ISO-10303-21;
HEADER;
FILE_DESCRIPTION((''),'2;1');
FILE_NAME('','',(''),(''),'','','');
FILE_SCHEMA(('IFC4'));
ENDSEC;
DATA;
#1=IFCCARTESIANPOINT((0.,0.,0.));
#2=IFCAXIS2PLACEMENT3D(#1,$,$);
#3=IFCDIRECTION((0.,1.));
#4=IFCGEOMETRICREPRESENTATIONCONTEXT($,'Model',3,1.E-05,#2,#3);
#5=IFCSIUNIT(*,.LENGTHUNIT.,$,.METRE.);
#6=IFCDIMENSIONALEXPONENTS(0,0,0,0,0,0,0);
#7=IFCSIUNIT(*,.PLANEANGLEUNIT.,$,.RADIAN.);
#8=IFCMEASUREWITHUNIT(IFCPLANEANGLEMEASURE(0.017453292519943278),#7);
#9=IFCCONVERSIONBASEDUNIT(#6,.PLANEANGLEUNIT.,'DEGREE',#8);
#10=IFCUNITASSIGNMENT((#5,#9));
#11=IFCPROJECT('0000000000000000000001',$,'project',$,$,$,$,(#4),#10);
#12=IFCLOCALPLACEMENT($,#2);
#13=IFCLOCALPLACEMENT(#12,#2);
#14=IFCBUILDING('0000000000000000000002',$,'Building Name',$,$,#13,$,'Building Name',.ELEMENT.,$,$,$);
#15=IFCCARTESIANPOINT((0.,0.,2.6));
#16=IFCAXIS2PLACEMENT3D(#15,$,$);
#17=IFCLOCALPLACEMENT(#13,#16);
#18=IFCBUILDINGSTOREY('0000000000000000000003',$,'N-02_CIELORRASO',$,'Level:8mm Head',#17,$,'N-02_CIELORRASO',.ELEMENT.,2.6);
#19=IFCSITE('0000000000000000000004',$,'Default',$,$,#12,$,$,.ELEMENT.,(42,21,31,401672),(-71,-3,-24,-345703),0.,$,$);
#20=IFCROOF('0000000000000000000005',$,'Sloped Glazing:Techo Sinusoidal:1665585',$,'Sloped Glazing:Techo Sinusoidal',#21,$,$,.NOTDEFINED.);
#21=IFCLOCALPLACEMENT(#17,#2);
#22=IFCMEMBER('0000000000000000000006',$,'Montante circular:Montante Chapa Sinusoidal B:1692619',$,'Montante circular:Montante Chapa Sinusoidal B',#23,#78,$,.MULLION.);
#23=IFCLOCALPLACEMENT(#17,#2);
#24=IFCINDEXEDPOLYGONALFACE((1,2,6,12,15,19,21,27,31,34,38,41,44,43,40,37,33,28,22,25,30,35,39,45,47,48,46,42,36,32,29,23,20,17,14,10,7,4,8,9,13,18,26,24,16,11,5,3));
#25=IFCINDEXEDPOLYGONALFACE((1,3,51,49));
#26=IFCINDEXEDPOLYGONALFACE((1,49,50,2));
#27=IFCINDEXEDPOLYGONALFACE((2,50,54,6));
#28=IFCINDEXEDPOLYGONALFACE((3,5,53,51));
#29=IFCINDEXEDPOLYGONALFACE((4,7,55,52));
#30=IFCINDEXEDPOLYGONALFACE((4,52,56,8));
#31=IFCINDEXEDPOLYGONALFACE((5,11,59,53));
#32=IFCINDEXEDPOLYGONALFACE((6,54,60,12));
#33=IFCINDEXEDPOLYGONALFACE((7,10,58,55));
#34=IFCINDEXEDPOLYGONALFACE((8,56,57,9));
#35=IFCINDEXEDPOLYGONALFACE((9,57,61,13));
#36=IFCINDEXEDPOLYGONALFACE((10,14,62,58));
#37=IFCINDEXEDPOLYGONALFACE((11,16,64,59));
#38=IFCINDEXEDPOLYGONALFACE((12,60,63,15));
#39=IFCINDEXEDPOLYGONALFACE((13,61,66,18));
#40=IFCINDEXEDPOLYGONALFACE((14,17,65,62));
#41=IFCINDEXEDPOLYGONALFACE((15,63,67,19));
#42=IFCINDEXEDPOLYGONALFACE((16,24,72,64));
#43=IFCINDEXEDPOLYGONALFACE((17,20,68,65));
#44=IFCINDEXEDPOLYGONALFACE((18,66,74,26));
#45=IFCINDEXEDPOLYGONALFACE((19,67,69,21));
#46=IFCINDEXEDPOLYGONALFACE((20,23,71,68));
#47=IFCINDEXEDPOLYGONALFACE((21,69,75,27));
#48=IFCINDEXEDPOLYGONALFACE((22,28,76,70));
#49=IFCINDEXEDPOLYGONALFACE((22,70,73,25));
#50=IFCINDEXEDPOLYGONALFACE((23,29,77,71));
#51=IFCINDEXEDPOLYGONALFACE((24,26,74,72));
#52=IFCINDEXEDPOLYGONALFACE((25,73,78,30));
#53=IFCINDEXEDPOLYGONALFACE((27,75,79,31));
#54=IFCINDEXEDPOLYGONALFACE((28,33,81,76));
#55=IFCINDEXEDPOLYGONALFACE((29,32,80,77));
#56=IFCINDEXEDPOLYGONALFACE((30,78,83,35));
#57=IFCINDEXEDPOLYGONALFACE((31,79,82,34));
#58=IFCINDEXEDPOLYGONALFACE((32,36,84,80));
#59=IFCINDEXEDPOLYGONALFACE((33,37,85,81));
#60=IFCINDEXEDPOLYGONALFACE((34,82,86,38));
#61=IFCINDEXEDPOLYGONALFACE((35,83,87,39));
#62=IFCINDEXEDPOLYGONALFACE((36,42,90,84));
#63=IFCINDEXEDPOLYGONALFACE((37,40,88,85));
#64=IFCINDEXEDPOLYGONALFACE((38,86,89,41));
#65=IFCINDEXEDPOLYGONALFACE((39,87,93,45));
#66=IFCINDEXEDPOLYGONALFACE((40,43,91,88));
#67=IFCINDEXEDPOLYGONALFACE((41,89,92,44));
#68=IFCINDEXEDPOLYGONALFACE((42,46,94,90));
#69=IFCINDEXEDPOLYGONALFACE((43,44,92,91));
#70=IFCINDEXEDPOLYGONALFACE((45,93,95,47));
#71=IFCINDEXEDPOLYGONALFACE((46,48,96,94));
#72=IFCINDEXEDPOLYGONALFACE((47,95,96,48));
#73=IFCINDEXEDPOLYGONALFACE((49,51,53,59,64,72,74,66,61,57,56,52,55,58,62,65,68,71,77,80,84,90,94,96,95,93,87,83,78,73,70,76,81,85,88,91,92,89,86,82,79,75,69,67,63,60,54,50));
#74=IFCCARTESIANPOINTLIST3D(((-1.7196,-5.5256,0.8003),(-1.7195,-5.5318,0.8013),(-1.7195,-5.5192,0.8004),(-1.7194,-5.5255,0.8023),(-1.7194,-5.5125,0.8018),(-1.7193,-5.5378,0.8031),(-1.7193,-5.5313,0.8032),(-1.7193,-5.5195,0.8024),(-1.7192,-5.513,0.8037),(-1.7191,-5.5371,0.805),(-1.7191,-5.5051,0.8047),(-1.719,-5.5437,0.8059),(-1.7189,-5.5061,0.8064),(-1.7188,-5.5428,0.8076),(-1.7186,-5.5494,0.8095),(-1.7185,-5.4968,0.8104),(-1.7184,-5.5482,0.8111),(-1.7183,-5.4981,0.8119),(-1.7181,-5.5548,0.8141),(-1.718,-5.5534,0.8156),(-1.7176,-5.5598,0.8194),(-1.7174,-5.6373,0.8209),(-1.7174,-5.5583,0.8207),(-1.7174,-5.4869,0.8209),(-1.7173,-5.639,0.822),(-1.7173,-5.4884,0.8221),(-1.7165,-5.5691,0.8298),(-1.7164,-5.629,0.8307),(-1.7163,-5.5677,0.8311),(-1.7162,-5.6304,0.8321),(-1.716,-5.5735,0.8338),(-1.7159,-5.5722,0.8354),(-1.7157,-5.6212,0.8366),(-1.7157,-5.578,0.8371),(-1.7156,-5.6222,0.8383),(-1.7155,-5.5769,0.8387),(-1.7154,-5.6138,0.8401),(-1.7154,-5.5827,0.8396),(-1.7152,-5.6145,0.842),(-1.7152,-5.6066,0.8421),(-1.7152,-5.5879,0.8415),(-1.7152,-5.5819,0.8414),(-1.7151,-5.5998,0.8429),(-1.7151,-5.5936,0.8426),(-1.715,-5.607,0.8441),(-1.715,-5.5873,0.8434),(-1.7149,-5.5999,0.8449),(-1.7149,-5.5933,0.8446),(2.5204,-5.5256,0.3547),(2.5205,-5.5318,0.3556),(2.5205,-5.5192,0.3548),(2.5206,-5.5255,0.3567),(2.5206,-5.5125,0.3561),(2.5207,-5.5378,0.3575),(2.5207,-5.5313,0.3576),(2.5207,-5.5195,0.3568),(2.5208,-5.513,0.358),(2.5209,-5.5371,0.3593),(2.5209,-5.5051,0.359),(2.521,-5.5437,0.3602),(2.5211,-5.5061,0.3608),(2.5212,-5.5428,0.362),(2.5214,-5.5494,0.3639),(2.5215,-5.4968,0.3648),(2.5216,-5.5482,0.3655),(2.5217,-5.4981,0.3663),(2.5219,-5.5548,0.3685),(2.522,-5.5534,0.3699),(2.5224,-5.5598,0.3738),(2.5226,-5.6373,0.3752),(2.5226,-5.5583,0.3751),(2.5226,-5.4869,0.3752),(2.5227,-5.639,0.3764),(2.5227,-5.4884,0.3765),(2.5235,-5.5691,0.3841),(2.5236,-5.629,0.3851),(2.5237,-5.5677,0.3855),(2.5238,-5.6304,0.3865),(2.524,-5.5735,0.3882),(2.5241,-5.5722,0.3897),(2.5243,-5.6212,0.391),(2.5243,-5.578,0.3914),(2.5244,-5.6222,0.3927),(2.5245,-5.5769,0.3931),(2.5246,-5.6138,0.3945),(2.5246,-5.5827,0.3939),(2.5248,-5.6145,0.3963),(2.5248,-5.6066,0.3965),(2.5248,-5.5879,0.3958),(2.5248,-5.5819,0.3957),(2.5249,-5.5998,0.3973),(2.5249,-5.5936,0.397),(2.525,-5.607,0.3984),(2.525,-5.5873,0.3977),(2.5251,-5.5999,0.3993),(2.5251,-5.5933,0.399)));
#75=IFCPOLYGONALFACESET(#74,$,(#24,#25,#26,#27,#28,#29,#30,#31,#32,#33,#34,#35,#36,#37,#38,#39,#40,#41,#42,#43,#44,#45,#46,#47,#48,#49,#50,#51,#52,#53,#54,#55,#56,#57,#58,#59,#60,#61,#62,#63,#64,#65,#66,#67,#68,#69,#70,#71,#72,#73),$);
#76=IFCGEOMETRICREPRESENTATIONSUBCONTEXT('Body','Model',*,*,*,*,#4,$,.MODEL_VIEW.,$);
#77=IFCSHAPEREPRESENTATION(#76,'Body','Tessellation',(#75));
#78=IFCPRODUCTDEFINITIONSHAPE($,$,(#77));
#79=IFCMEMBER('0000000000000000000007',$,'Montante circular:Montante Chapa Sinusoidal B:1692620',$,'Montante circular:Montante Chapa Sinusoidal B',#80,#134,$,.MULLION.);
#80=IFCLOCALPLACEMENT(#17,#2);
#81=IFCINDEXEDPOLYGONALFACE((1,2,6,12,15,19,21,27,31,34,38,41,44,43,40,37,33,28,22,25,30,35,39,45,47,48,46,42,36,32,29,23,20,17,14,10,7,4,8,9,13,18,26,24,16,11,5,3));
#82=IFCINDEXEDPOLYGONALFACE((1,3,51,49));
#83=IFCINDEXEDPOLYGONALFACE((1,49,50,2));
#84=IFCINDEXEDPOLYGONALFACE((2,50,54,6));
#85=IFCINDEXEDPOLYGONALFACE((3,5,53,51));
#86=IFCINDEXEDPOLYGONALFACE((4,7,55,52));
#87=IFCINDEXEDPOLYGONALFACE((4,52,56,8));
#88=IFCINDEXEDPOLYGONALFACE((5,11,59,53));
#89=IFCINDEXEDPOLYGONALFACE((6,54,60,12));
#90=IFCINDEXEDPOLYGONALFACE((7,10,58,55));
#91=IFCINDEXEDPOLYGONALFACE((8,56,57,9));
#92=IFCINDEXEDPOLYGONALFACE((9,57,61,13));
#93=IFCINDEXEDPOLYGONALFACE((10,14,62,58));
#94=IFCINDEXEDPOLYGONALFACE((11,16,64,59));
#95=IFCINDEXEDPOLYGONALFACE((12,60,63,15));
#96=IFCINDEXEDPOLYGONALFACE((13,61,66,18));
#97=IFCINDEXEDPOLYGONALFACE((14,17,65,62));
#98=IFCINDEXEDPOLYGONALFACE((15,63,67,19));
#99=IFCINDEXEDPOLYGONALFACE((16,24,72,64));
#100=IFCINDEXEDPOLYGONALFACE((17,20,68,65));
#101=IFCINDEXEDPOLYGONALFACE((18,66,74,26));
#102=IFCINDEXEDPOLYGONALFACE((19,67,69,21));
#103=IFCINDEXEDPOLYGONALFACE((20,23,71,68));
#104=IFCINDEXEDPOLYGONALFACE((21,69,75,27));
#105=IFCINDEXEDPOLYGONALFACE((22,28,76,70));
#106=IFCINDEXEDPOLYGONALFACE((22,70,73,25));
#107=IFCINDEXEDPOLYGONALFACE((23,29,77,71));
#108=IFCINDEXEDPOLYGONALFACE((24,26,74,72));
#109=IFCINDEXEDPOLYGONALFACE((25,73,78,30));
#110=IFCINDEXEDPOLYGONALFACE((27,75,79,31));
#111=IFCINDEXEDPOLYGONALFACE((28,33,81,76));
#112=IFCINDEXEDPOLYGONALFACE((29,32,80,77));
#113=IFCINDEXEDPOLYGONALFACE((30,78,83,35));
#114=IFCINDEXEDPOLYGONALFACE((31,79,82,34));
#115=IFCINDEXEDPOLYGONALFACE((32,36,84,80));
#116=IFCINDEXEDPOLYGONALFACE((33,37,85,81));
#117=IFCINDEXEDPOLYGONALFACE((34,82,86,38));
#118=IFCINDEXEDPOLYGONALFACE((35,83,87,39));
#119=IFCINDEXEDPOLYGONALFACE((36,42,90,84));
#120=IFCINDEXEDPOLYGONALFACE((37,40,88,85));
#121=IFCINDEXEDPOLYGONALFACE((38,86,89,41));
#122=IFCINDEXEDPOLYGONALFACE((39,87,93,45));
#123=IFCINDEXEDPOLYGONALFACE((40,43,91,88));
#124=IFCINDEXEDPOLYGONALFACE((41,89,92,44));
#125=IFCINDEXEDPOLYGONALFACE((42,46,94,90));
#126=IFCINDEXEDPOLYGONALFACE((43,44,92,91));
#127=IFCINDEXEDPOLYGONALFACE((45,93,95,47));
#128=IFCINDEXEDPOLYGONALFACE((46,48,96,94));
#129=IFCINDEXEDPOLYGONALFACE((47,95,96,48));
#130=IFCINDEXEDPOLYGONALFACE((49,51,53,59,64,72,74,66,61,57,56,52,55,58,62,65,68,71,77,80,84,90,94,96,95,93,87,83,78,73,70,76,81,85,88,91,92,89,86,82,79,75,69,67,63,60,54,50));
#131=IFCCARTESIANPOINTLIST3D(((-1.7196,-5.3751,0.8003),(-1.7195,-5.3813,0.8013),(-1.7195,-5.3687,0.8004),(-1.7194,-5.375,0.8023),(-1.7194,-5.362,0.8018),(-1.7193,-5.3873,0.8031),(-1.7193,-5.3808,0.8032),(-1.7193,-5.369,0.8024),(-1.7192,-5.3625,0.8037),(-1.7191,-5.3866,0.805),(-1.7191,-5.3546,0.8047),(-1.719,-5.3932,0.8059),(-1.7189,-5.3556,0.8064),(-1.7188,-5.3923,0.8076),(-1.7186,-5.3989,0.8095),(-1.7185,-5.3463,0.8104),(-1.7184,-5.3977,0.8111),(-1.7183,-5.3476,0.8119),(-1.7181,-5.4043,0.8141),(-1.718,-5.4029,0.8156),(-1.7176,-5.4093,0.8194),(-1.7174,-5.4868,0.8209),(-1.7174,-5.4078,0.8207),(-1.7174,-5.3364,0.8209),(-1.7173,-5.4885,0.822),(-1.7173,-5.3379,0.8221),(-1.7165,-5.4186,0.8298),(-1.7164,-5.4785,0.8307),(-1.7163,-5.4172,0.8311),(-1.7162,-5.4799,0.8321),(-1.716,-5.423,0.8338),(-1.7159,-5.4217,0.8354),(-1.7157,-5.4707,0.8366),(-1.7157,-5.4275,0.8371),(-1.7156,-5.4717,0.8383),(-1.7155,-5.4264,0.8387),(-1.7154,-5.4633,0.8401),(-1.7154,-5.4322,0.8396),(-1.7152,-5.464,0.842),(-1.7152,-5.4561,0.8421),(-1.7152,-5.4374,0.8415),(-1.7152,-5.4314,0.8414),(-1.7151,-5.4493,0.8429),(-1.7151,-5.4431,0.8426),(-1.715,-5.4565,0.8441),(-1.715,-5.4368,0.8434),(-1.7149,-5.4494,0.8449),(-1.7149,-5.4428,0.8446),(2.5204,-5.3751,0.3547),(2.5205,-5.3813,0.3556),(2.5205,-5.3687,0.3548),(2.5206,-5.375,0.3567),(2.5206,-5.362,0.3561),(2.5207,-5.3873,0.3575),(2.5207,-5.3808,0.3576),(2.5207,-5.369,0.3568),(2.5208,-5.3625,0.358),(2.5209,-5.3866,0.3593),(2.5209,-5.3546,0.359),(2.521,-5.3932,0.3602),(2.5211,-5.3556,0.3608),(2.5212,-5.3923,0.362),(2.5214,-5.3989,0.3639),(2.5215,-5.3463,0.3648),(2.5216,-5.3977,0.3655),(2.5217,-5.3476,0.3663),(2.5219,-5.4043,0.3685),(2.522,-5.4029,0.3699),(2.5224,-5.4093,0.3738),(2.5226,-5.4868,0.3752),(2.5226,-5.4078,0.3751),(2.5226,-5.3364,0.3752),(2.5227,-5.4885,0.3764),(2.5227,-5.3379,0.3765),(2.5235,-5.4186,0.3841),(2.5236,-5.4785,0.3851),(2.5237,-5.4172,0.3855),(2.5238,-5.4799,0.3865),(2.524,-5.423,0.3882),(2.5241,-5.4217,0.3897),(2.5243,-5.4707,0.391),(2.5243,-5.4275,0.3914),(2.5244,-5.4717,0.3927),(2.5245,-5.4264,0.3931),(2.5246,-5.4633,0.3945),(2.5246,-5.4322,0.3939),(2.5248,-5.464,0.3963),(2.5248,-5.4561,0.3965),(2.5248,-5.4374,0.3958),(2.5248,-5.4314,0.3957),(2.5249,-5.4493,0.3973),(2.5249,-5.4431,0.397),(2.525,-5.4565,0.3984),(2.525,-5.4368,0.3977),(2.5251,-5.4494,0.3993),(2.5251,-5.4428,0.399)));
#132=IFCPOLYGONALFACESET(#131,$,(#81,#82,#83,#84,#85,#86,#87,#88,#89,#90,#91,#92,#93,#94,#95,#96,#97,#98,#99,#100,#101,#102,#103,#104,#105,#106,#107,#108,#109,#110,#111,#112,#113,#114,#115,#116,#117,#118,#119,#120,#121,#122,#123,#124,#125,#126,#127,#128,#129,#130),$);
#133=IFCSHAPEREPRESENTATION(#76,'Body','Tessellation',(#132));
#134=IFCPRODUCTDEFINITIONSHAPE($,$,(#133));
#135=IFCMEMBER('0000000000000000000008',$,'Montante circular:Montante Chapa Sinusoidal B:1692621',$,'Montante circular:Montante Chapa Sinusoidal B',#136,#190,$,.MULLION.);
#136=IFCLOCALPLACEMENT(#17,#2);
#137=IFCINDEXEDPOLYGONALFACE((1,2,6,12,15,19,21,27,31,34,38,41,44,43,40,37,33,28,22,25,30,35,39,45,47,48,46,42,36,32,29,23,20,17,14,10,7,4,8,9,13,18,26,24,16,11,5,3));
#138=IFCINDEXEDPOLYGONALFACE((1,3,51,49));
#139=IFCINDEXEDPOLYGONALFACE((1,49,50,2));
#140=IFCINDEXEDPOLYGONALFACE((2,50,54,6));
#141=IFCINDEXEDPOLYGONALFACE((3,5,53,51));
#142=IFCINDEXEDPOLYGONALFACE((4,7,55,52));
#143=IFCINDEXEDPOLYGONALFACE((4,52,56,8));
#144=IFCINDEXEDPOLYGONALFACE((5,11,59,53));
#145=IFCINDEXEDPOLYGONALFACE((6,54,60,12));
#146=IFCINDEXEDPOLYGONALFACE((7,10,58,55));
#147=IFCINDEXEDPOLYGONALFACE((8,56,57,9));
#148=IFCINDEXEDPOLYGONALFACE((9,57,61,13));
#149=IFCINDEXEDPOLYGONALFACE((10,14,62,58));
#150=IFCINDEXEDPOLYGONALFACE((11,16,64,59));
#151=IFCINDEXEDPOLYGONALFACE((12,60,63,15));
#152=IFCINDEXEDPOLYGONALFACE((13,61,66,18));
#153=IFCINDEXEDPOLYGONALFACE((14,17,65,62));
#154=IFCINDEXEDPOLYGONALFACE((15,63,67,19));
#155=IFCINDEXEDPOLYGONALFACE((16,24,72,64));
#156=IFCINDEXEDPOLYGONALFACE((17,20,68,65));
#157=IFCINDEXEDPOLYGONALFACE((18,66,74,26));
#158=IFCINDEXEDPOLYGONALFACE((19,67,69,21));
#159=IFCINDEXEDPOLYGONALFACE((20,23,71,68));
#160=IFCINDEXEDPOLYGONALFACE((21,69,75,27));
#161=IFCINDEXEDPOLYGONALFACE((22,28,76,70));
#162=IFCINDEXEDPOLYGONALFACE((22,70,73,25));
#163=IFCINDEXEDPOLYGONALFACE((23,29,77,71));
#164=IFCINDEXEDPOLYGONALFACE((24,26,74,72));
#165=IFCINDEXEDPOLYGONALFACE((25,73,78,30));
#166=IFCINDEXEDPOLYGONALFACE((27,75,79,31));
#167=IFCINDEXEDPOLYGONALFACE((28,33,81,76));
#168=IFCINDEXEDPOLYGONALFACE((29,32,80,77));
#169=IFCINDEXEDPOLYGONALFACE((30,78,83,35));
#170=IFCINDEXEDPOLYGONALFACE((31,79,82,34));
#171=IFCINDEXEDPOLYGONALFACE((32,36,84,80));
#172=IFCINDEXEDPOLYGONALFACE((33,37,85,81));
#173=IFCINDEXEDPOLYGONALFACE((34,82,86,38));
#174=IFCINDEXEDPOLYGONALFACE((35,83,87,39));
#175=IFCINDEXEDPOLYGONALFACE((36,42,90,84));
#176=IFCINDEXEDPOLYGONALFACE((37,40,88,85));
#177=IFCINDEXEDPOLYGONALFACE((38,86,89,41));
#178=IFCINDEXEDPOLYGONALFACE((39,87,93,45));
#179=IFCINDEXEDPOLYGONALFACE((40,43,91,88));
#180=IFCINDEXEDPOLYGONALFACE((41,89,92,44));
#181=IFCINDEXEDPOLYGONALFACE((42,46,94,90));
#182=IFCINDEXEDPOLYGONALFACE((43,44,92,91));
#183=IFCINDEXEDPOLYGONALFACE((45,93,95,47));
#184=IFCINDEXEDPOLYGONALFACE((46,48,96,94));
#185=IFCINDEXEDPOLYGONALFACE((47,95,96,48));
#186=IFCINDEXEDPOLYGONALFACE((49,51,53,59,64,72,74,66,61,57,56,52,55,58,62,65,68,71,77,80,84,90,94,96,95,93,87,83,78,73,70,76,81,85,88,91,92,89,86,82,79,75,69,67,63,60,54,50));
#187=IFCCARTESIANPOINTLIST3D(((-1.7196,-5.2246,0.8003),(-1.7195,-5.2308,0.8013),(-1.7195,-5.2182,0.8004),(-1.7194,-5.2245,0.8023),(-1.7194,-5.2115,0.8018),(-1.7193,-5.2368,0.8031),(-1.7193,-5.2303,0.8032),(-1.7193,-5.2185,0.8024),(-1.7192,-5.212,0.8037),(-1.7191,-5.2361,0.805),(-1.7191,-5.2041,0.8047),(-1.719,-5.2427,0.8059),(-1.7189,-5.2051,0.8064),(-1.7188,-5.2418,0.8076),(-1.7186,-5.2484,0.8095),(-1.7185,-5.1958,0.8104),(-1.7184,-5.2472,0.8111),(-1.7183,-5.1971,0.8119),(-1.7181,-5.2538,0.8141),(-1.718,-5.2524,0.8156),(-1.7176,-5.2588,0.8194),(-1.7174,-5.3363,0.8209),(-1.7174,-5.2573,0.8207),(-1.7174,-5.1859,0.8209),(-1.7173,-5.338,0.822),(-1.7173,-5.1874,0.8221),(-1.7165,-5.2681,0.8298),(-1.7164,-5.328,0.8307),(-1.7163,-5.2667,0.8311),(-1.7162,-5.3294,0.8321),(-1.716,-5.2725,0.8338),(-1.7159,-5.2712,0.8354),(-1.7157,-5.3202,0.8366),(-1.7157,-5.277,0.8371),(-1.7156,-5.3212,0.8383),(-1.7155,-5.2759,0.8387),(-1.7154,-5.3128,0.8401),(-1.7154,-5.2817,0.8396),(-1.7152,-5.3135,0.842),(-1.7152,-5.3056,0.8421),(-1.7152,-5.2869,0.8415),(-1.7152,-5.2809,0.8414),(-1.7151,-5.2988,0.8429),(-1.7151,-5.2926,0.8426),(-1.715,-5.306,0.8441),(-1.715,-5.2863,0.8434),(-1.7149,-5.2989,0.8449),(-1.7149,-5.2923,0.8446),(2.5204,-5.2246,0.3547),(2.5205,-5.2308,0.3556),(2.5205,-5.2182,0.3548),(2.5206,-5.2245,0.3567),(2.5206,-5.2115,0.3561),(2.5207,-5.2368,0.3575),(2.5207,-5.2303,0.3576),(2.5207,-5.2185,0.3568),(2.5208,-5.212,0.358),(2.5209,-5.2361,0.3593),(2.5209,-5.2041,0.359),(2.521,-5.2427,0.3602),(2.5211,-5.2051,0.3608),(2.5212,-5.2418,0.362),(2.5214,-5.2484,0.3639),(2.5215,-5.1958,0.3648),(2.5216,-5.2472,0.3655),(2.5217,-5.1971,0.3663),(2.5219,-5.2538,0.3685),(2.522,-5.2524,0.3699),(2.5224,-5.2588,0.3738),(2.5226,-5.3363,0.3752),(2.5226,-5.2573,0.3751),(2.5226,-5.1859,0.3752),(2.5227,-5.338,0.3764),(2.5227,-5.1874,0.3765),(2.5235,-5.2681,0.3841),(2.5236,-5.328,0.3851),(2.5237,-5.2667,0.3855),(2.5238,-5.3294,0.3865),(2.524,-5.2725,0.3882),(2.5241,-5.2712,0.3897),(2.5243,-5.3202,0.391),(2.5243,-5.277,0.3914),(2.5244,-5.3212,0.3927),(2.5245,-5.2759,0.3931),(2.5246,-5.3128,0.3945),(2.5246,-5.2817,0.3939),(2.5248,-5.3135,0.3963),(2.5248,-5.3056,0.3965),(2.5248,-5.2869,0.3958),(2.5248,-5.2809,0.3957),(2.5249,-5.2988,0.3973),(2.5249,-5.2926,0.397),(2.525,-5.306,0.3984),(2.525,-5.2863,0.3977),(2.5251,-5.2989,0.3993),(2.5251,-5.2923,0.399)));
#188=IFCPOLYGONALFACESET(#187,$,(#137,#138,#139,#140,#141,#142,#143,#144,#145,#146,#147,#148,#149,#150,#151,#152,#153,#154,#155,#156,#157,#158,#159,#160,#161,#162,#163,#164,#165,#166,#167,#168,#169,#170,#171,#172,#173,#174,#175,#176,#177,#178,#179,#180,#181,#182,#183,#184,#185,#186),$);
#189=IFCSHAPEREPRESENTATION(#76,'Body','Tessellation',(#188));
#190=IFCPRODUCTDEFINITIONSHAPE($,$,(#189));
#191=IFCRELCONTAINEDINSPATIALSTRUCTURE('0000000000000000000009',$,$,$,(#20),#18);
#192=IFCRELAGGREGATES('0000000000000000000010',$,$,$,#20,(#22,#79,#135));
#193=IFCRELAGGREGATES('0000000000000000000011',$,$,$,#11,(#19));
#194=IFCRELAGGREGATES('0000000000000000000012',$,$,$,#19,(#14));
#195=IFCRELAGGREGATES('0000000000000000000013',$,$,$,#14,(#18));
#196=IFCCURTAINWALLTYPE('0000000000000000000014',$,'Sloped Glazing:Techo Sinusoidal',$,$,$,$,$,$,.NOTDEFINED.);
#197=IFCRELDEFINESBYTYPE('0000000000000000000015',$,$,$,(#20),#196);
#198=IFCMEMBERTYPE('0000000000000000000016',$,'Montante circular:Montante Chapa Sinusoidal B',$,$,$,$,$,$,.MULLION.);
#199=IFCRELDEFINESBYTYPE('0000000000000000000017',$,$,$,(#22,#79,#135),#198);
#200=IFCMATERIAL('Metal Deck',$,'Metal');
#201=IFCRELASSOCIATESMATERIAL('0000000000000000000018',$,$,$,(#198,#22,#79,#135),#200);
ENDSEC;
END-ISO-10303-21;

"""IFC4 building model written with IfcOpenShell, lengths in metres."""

from ifc_helpers import new_model, entity, si_unit, converted_unit, direction, frame, origin, place, context, subcontext, project, spatial, indexed_curve, outline, extrude, source, transform, mapped, material, type_object, type_shapes, element, aggregate, save


model = new_model("IFC4")

# Units and contexts
model_context = context("Model", 3, precision=1e-05, world=origin(), true_north=direction((0.0, 1.0)))
body_context = subcontext(model_context, "Body", "Model", "MODEL_VIEW")
ifc_project = project(units=[si_unit("LENGTHUNIT", "METRE"), converted_unit("PLANEANGLEUNIT", "DEGREE", entity("IfcPlaneAngleMeasure", 0.017453292519943278), si_unit("PLANEANGLEUNIT", "RADIAN"), dimensions=[0, 0, 0, 0, 0, 0, 0])], contexts=[model_context])

# Site, building, storey
site_placement = place(None, origin())
site = spatial("IfcSite", under=ifc_project, at=site_placement, Name="Default", CompositionType="ELEMENT", RefLatitude=(42, 21, 31, 401672), RefLongitude=(-71, -3, -24, -345703), RefElevation=0.0)
building_placement = place(site_placement, origin())
building = spatial("IfcBuilding", under=site, at=building_placement, Name="Building Name", LongName="Building Name", CompositionType="ELEMENT")
storey_placement = place(building_placement, frame((0.0, 0.0, 2.6)))
storey = spatial("IfcBuildingStorey", under=building, at=storey_placement, Name="N-02_CIELORRASO", ObjectType="Level:8mm Head", LongName="N-02_CIELORRASO", CompositionType="ELEMENT", Elevation=2.6)

# Roof, members
curtain_wall_type = type_object("IfcCurtainWallType", Name="Sloped Glazing:Techo Sinusoidal", PredefinedType="NOTDEFINED")
roof_1_placement = place(storey_placement, frame((0.0, 0.0, -2.6)))
roof_1 = element("IfcRoof", 1, at=roof_1_placement, inside=storey, type_object=curtain_wall_type, Name="Sloped Glazing:Techo Sinusoidal:1665585", ObjectType="Sloped Glazing:Techo Sinusoidal", PredefinedType="NOTDEFINED")
ifc_material = material(Name="Metal Deck", Category="Metal")
member_type_1 = type_object("IfcMemberType", Name="Montante circular:Montante Chapa Sinusoidal B", PredefinedType="MULLION", material=ifc_material)
shared_shape_1 = source(origin(), body_context, "Body", "SweptSolid", [
    extrude(outline(indexed_curve([(0.0595, -0.0443), (0.0615, -0.0443), (0.0603, -0.031), (0.0572, -0.0213), (0.053, -0.0138), (0.0481, -0.0078), (0.0427, -0.003), (0.0372, 0.0005), (0.0315, 0.0029), (0.0259, 0.0044), (0.0203, 0.0051), (0.0146, 0.005), (0.0084, 0.0041), (-0.0053, 0.0009), (-0.0123, -0.0005), (-0.0191, -0.0012), (-0.0256, -0.001), (-0.0317, 0.0001), (-0.0375, 0.0019), (-0.0428, 0.0046), (-0.0477, 0.0081), (-0.0522, 0.0128), (-0.0563, 0.0191), (-0.0597, 0.0282), (-0.0617, 0.0421), (-0.0637, 0.042), (-0.0616, 0.0277), (-0.0581, 0.0182), (-0.0537, 0.0116), (-0.049, 0.0066), (-0.0438, 0.0028), (-0.0382, 0.0001), (-0.0322, -0.0019), (-0.0258, -0.003), (-0.019, -0.0032), (-0.012, -0.0025), (-0.0048, -0.0011), (0.0088, 0.0021), (0.0147, 0.003), (0.0202, 0.0031), (0.0255, 0.0024), (0.0309, 0.001), (0.0362, -0.0013), (0.0415, -0.0046), (0.0466, -0.0092), (0.0513, -0.0149), (0.0554, -0.0221), (0.0584, -0.0314), (0.0595, -0.0443)], self_intersect=False)), frame((-0.007, 0.0228, -4.2634), z_axis=(0.0, 0.0, 1.0), x_axis=(-0.819152, -0.573576, 0.0)), (0.0, 0.0, 1.0), 4.2634),
])
type_shapes(member_type_1, [shared_shape_1])
member_1_placement = place(roof_1_placement, frame((-1.7148, -5.5561, 3.4456), z_axis=(-0.994522, 0.0, 0.104528), x_axis=(0.0, 1.0, 0.0)))
member_1 = element("IfcMember", 2, at=member_1_placement, type_object=member_type_1, material=ifc_material, Name="Montante circular:Montante Chapa Sinusoidal B:1692619", ObjectType="Montante circular:Montante Chapa Sinusoidal B", PredefinedType="MULLION", context=body_context, shape_type="MappedRepresentation", body=[
    mapped(shared_shape_1, transform((0.0, 0.0, 0.0), scale=1.0)),
])
member_2_placement = place(roof_1_placement, frame((-1.7148, -5.4056, 3.4456), z_axis=(-0.994522, 0.0, 0.104528), x_axis=(0.0, 1.0, 0.0)))
member_2 = element("IfcMember", 3, at=member_2_placement, type_object=member_type_1, material=ifc_material, Name="Montante circular:Montante Chapa Sinusoidal B:1692620", ObjectType="Montante circular:Montante Chapa Sinusoidal B", PredefinedType="MULLION", context=body_context, shape_type="MappedRepresentation", body=[
    mapped(shared_shape_1, transform((0.0, 0.0, 0.0), scale=1.0)),
])
member_3_placement = place(roof_1_placement, frame((-1.7148, -5.2551, 3.4456), z_axis=(-0.994522, 0.0, 0.104528), x_axis=(0.0, 1.0, 0.0)))
member_3 = element("IfcMember", 4, at=member_3_placement, type_object=member_type_1, material=ifc_material, Name="Montante circular:Montante Chapa Sinusoidal B:1692621", ObjectType="Montante circular:Montante Chapa Sinusoidal B", PredefinedType="MULLION", context=body_context, shape_type="MappedRepresentation", body=[
    mapped(shared_shape_1, transform((0.0, 0.0, 0.0), scale=1.0)),
])
aggregate(roof_1, [member_1, member_2, member_3])

save(model, "model.ifc")
